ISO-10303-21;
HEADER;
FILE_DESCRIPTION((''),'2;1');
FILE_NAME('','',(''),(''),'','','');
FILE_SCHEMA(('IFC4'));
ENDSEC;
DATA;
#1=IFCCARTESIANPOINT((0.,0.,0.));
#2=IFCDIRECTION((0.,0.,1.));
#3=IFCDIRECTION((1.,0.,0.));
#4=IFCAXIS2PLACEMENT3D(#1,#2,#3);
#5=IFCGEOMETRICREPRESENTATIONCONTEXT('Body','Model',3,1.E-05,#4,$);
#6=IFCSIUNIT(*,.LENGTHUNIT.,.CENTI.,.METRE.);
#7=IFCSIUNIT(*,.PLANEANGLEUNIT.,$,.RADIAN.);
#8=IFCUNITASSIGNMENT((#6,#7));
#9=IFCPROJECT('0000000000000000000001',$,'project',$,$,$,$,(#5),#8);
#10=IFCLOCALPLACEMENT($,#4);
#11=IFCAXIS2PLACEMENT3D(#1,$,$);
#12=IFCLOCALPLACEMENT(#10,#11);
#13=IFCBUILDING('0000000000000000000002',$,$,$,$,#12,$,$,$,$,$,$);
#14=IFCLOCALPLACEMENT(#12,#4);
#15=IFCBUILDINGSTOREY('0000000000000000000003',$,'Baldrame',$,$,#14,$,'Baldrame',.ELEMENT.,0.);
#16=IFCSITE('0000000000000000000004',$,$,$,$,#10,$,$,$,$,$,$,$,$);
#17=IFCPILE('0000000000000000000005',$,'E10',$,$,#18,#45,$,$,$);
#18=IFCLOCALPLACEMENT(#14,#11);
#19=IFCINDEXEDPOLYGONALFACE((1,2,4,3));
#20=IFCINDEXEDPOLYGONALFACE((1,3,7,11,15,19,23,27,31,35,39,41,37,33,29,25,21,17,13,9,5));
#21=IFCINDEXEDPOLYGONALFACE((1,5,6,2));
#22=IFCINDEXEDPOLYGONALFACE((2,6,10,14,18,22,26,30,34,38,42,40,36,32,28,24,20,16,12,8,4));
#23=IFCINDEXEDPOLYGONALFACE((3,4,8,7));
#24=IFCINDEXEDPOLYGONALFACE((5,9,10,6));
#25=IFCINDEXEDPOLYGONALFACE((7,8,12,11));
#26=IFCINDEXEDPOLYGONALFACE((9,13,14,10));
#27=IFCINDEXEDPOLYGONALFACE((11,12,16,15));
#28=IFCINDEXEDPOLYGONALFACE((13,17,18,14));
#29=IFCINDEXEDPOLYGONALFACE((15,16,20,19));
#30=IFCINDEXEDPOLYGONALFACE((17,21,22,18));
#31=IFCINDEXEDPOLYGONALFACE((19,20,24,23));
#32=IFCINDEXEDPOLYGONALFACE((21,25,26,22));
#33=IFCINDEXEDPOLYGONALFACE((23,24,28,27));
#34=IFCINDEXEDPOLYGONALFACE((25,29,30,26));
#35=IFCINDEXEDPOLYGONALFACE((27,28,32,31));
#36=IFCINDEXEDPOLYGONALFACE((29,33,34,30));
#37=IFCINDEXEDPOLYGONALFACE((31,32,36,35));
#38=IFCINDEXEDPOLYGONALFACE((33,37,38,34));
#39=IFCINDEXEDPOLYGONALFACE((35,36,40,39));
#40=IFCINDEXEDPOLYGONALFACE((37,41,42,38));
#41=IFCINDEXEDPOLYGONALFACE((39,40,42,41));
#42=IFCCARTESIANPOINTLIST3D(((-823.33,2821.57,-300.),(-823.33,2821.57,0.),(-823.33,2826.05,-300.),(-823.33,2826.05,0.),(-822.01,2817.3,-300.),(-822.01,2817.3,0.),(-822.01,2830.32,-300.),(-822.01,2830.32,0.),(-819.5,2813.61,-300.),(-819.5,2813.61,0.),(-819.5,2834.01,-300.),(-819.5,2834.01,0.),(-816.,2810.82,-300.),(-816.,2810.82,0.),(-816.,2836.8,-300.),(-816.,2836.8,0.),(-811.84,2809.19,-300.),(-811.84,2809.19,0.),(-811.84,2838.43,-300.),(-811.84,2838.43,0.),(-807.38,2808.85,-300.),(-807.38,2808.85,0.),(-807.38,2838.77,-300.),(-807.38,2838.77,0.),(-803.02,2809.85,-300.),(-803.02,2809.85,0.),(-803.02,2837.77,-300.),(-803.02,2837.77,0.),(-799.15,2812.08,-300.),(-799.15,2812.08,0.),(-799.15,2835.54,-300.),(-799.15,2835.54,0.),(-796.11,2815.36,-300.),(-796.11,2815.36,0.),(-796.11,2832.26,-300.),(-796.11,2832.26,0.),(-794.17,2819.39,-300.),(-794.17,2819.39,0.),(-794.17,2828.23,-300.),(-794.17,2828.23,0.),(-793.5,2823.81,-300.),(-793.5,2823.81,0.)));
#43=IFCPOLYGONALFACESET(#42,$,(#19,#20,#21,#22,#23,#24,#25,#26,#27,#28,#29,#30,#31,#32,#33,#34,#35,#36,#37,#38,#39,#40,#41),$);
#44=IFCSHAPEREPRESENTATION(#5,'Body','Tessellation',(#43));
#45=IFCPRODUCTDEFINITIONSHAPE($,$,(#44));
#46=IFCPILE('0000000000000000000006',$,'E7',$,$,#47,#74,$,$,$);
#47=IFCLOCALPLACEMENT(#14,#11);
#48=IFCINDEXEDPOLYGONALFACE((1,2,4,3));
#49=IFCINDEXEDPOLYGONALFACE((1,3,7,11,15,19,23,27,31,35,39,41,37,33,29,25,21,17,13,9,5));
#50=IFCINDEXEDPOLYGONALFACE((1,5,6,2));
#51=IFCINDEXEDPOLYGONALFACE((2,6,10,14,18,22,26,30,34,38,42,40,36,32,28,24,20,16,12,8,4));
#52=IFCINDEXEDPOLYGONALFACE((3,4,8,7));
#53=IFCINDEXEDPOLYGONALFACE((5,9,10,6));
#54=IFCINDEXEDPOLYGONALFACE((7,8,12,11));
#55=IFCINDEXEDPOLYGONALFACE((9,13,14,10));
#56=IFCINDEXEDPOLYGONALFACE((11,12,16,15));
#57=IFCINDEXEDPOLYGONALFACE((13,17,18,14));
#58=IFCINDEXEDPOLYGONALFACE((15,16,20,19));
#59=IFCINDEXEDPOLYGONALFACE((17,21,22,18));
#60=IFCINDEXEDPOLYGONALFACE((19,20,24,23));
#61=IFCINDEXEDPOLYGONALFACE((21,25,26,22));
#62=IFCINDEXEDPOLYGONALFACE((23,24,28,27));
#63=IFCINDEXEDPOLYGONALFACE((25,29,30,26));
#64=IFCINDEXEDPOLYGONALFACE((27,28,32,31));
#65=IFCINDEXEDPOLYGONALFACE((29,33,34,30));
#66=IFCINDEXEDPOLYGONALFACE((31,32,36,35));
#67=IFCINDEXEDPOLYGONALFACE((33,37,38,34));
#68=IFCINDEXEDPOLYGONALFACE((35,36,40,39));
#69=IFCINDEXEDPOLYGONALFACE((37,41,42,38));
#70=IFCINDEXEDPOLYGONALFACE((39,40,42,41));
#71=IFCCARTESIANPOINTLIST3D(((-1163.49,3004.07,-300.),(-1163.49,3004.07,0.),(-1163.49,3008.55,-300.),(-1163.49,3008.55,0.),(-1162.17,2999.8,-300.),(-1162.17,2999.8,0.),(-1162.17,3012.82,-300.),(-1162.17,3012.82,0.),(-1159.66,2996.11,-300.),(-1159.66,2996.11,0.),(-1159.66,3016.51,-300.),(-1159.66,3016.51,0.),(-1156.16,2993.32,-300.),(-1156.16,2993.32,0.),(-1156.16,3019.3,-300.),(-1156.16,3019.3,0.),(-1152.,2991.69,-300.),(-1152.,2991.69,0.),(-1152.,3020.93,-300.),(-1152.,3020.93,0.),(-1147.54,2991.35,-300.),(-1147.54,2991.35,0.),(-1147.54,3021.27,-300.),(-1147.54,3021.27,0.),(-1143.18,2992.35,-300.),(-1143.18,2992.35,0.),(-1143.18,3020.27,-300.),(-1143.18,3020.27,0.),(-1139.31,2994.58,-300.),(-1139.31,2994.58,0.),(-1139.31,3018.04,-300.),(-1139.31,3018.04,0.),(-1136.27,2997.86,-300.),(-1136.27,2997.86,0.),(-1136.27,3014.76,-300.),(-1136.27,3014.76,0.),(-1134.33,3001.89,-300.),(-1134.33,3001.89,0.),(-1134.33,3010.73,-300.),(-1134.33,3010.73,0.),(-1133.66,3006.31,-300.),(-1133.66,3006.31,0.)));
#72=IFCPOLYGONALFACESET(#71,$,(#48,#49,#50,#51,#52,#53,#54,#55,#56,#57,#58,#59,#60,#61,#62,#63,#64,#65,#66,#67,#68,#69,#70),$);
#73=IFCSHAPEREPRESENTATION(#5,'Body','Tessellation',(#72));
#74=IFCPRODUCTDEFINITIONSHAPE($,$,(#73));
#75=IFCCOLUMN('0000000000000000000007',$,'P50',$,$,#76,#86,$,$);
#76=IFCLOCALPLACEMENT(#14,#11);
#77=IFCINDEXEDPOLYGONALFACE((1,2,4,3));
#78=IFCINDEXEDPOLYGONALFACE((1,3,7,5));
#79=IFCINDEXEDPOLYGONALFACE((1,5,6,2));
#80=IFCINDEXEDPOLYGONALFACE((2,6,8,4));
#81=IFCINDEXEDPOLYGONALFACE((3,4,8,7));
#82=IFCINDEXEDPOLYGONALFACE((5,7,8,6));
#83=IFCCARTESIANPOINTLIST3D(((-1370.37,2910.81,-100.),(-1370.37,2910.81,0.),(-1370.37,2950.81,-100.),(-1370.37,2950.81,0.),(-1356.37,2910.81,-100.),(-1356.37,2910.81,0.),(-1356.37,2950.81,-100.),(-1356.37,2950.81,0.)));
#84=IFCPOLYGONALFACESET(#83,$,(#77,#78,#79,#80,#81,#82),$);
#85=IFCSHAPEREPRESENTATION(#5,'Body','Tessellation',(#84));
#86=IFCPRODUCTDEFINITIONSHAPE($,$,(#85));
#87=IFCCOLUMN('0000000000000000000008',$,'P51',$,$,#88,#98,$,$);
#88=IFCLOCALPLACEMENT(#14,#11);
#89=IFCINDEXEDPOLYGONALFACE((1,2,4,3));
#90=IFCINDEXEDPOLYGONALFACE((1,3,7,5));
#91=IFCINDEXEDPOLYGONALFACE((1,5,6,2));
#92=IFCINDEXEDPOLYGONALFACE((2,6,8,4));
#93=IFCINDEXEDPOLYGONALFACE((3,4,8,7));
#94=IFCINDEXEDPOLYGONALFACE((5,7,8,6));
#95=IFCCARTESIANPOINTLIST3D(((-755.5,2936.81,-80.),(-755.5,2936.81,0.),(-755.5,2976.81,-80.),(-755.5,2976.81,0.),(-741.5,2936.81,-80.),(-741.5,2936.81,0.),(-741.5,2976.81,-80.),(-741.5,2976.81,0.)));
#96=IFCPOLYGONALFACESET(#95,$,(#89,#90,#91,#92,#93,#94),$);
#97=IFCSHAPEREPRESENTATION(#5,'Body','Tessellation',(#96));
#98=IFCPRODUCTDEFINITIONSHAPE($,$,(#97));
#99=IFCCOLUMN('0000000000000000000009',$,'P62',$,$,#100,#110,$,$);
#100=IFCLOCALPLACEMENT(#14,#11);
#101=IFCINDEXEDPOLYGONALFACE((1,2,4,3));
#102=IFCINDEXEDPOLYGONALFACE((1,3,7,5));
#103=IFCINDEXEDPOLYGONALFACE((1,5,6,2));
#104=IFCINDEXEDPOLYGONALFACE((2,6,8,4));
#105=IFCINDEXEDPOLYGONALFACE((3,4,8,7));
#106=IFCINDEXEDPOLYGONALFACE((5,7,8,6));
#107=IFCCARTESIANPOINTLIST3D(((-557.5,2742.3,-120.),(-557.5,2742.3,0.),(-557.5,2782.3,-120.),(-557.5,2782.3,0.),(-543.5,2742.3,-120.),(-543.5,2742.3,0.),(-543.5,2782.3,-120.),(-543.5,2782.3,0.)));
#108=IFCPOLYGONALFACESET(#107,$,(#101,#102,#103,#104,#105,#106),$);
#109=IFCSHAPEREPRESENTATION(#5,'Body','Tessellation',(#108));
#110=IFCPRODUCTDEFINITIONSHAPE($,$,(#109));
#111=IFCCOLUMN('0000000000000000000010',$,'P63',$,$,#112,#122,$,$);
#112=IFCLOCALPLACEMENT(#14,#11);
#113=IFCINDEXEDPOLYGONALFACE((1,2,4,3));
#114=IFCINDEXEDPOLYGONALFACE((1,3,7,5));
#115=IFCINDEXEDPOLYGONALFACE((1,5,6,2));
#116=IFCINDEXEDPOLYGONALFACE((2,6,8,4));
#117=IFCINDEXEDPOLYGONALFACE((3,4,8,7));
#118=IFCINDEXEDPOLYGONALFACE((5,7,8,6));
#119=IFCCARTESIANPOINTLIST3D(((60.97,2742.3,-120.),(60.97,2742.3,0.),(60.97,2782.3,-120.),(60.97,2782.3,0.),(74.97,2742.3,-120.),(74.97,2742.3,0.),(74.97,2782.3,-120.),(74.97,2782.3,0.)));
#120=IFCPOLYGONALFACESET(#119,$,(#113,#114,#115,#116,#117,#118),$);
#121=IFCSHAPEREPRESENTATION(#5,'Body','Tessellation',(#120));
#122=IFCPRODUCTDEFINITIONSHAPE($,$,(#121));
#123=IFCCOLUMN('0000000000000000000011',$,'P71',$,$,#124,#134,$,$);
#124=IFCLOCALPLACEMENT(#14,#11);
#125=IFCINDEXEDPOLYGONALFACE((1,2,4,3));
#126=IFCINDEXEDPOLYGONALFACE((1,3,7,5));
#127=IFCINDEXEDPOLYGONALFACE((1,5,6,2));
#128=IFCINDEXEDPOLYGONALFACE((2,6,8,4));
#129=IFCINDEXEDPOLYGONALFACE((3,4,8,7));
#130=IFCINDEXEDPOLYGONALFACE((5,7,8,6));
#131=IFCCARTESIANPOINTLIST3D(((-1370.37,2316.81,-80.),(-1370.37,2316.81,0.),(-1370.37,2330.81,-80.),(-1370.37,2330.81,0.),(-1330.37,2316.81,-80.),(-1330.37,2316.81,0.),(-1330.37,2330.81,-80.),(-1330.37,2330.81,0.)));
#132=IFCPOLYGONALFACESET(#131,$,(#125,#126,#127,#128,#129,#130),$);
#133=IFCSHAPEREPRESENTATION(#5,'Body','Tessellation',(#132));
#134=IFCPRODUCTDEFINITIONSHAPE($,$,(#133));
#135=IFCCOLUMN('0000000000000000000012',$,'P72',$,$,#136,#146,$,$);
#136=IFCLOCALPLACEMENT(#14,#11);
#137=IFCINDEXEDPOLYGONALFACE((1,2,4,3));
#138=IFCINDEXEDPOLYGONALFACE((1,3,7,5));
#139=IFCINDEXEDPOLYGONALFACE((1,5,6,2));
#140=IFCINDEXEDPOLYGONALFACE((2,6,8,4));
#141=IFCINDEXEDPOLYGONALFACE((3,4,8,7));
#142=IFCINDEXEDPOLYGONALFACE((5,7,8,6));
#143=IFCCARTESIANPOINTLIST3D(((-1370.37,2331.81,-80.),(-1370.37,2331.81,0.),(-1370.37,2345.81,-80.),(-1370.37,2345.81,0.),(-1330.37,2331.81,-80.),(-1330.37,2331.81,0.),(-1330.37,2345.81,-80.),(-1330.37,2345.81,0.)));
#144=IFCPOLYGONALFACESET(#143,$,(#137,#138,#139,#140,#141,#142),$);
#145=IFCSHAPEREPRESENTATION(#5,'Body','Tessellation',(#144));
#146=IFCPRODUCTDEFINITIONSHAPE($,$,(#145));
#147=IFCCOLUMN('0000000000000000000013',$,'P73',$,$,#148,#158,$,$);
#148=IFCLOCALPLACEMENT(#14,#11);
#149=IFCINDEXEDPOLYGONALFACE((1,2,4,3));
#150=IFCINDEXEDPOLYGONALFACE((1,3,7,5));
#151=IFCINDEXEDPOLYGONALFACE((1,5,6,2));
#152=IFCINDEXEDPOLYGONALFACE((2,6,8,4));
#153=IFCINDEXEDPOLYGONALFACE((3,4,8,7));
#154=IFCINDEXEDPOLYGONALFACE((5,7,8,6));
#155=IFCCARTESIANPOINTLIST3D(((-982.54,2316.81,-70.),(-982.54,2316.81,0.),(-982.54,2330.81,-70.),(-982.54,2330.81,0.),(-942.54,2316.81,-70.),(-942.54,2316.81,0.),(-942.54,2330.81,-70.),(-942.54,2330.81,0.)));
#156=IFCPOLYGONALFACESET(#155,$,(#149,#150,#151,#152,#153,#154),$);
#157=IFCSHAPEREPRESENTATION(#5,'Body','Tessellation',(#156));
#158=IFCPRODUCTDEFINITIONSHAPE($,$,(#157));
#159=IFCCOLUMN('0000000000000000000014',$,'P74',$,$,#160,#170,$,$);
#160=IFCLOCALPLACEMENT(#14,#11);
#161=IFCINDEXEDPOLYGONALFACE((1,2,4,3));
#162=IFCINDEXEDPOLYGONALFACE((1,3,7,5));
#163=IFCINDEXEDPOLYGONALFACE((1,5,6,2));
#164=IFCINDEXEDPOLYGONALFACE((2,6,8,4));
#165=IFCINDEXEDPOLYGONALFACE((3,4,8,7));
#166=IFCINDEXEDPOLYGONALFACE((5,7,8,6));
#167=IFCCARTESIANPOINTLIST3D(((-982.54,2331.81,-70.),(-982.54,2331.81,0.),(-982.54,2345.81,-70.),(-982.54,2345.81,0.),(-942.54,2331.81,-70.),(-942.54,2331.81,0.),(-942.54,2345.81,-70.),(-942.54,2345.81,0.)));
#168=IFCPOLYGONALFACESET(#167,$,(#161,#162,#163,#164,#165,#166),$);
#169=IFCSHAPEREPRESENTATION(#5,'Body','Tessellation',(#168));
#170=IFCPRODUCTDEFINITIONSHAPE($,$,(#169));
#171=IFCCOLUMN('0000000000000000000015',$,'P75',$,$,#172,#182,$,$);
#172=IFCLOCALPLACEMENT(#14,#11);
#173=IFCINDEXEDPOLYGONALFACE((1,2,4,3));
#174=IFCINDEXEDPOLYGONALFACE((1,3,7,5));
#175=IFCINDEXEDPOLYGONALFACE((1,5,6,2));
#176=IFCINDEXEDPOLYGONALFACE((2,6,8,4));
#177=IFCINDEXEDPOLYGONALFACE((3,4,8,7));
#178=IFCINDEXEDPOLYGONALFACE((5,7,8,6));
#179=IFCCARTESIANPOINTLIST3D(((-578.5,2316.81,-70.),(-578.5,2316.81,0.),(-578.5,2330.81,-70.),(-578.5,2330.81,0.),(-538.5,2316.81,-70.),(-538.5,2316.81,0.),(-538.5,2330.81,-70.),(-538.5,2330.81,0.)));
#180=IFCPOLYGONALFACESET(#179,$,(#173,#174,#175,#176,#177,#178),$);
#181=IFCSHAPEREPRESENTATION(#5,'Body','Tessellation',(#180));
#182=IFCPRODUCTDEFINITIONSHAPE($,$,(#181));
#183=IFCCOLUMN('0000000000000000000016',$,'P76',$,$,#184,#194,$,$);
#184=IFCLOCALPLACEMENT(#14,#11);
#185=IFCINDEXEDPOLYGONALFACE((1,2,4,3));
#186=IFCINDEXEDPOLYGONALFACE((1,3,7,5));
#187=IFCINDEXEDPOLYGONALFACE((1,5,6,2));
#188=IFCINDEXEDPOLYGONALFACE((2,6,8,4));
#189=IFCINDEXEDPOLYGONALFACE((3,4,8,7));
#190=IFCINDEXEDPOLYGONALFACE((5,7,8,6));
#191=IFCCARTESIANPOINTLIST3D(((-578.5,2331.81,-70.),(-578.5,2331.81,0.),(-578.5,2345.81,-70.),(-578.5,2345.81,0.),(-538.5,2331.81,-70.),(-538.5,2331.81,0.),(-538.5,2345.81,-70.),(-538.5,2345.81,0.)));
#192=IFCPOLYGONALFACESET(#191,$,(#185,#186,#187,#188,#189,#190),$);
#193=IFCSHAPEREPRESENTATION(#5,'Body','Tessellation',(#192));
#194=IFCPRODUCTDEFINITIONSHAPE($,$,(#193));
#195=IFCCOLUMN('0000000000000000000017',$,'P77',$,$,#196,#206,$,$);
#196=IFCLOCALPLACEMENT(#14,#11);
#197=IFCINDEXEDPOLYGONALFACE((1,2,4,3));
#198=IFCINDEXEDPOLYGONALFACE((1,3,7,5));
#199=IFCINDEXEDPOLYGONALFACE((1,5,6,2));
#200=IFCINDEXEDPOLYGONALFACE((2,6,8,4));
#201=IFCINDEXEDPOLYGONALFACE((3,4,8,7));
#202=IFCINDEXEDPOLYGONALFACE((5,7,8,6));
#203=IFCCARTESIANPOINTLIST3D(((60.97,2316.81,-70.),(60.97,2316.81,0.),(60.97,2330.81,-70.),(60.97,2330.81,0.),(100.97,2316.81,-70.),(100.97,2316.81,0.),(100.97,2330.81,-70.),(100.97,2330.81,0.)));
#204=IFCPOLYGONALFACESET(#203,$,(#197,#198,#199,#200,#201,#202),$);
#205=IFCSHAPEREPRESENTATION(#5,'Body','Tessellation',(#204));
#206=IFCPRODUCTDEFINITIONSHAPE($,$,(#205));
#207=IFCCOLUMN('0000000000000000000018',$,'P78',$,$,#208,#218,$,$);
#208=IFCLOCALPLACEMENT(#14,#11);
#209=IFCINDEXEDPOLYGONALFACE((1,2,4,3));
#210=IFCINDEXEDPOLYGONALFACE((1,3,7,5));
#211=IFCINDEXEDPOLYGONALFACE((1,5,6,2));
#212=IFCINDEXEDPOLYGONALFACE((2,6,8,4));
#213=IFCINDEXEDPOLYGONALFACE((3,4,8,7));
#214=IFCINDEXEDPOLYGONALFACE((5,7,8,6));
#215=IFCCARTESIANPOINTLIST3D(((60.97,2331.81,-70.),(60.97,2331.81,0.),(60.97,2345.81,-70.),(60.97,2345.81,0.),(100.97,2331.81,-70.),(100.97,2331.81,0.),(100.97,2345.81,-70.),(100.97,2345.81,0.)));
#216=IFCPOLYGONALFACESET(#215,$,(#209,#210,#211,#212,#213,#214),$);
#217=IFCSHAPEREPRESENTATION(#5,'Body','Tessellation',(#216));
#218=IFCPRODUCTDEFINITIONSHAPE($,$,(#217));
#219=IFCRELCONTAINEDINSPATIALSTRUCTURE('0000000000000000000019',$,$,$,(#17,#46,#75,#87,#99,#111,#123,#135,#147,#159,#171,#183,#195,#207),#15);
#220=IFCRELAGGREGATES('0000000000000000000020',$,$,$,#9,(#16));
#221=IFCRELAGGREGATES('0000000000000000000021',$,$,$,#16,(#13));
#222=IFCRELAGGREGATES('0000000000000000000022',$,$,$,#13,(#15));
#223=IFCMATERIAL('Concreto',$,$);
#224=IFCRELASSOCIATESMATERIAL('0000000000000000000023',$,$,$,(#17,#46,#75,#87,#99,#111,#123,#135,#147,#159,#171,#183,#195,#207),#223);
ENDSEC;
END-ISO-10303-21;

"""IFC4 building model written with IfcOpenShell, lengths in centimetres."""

from ifc_helpers import new_model, si_unit, frame, origin, origin_with_axes, origin_2d_with_axis, place, context, project, spatial, rectangle, circle, extrude, material, element, save


model = new_model("IFC4")

# Units and contexts
model_context = context("Model", 3, precision=1e-05, world=origin_with_axes(), identifier="Body")
ifc_project = project(units=[si_unit("LENGTHUNIT", "METRE", prefix="CENTI"), si_unit("PLANEANGLEUNIT", "RADIAN")], contexts=[model_context])

# Site, building, storey
site_placement = place(None, origin_with_axes())
site = spatial("IfcSite", under=ifc_project, at=site_placement)
building_placement = place(site_placement, origin())
building = spatial("IfcBuilding", under=site, at=building_placement)
storey_placement = place(building_placement, origin_with_axes())
storey = spatial("IfcBuildingStorey", under=building, at=storey_placement, Name="Baldrame", LongName="Baldrame", CompositionType="ELEMENT", Elevation=0.0)

# Piles
ifc_material = material(Name="Concreto")
for number, where, z_axis, x_axis, name in (
    (1, (-808.5, 2823.81, 0.0), (0.0, 0.0, 1.0), (1.0, 0.0, 0.0), "E10"),
    (2, (-1148.66, 3006.31, 0.0), (0.0, 0.0, 1.0), (1.0, 0.0, 0.0), "E7"),
):
    element("IfcPile", number, at=place(storey_placement, frame(where, z_axis=z_axis, x_axis=x_axis)), inside=storey, material=ifc_material, Name=name, context=model_context, shape_type="SolidModel", body=[
        extrude(circle(Radius=15.0, at=origin_2d_with_axis()), frame((0.0, 0.0, -300.0), z_axis=(0.0, 0.0, 1.0), x_axis=(1.0, 0.0, 0.0)), (0.0, 0.0, 1.0), 300.0),
    ])

# Columns
column_1_placement = place(storey_placement, frame((-1363.37, 2930.81, 0.0), z_axis=(0.0, 0.0, 1.0), x_axis=(1.0, 0.0, 0.0)))
element("IfcColumn", 3, at=column_1_placement, inside=storey, material=ifc_material, Name="P50", context=model_context, shape_type="SolidModel", body=[
    extrude(rectangle(XDim=14.0, YDim=40.0, at=origin_2d_with_axis()), frame((0.0, 0.0, -100.0), z_axis=(0.0, 0.0, 1.0), x_axis=(1.0, 0.0, 0.0)), (0.0, 0.0, 1.0), 100.0),
])
column_2_placement = place(storey_placement, frame((-748.5, 2956.81, 0.0), z_axis=(0.0, 0.0, 1.0), x_axis=(1.0, 0.0, 0.0)))
element("IfcColumn", 4, at=column_2_placement, inside=storey, material=ifc_material, Name="P51", context=model_context, shape_type="SolidModel", body=[
    extrude(rectangle(XDim=14.0, YDim=40.0, at=origin_2d_with_axis()), frame((0.0, 0.0, -80.0), z_axis=(0.0, 0.0, 1.0), x_axis=(1.0, 0.0, 0.0)), (0.0, 0.0, 1.0), 80.0),
])
for number, where, z_axis, x_axis, name in (
    (5, (-550.5, 2762.3, 0.0), (0.0, 0.0, 1.0), (1.0, 0.0, 0.0), "P62"),
    (6, (67.97, 2762.3, 0.0), (0.0, 0.0, 1.0), (1.0, 0.0, 0.0), "P63"),
):
    element("IfcColumn", number, at=place(storey_placement, frame(where, z_axis=z_axis, x_axis=x_axis)), inside=storey, material=ifc_material, Name=name, context=model_context, shape_type="SolidModel", body=[
        extrude(rectangle(XDim=14.0, YDim=40.0, at=origin_2d_with_axis()), frame((0.0, 0.0, -120.0), z_axis=(0.0, 0.0, 1.0), x_axis=(1.0, 0.0, 0.0)), (0.0, 0.0, 1.0), 120.0),
    ])
for number, where, z_axis, x_axis, name in (
    (7, (-1350.37, 2323.81, 0.0), (0.0, 0.0, 1.0), (1.0, 0.0, 0.0), "P71"),
    (8, (-1350.37, 2338.81, 0.0), (0.0, 0.0, 1.0), (1.0, 0.0, 0.0), "P72"),
):
    element("IfcColumn", number, at=place(storey_placement, frame(where, z_axis=z_axis, x_axis=x_axis)), inside=storey, material=ifc_material, Name=name, context=model_context, shape_type="SolidModel", body=[
        extrude(rectangle(XDim=14.0, YDim=40.0, at=origin_2d_with_axis()), frame((0.0, 0.0, -80.0), z_axis=(0.0, 0.0, 1.0), x_axis=(0.0, -1.0, 0.0)), (0.0, 0.0, 1.0), 80.0),
    ])
for number, where, z_axis, x_axis, name in (
    (9, (-962.54, 2323.81, 0.0), (0.0, 0.0, 1.0), (1.0, 0.0, 0.0), "P73"),
    (10, (-962.54, 2338.81, 0.0), (0.0, 0.0, 1.0), (1.0, 0.0, 0.0), "P74"),
    (11, (-558.5, 2323.81, 0.0), (0.0, 0.0, 1.0), (1.0, 0.0, 0.0), "P75"),
    (12, (-558.5, 2338.81, 0.0), (0.0, 0.0, 1.0), (1.0, 0.0, 0.0), "P76"),
    (13, (80.97, 2323.81, 0.0), (0.0, 0.0, 1.0), (1.0, 0.0, 0.0), "P77"),
    (14, (80.97, 2338.81, 0.0), (0.0, 0.0, 1.0), (1.0, 0.0, 0.0), "P78"),
):
    element("IfcColumn", number, at=place(storey_placement, frame(where, z_axis=z_axis, x_axis=x_axis)), inside=storey, material=ifc_material, Name=name, context=model_context, shape_type="SolidModel", body=[
        extrude(rectangle(XDim=14.0, YDim=40.0, at=origin_2d_with_axis()), frame((0.0, 0.0, -70.0), z_axis=(0.0, 0.0, 1.0), x_axis=(0.0, -1.0, 0.0)), (0.0, 0.0, 1.0), 70.0),
    ])

save(model, "model.ifc")
